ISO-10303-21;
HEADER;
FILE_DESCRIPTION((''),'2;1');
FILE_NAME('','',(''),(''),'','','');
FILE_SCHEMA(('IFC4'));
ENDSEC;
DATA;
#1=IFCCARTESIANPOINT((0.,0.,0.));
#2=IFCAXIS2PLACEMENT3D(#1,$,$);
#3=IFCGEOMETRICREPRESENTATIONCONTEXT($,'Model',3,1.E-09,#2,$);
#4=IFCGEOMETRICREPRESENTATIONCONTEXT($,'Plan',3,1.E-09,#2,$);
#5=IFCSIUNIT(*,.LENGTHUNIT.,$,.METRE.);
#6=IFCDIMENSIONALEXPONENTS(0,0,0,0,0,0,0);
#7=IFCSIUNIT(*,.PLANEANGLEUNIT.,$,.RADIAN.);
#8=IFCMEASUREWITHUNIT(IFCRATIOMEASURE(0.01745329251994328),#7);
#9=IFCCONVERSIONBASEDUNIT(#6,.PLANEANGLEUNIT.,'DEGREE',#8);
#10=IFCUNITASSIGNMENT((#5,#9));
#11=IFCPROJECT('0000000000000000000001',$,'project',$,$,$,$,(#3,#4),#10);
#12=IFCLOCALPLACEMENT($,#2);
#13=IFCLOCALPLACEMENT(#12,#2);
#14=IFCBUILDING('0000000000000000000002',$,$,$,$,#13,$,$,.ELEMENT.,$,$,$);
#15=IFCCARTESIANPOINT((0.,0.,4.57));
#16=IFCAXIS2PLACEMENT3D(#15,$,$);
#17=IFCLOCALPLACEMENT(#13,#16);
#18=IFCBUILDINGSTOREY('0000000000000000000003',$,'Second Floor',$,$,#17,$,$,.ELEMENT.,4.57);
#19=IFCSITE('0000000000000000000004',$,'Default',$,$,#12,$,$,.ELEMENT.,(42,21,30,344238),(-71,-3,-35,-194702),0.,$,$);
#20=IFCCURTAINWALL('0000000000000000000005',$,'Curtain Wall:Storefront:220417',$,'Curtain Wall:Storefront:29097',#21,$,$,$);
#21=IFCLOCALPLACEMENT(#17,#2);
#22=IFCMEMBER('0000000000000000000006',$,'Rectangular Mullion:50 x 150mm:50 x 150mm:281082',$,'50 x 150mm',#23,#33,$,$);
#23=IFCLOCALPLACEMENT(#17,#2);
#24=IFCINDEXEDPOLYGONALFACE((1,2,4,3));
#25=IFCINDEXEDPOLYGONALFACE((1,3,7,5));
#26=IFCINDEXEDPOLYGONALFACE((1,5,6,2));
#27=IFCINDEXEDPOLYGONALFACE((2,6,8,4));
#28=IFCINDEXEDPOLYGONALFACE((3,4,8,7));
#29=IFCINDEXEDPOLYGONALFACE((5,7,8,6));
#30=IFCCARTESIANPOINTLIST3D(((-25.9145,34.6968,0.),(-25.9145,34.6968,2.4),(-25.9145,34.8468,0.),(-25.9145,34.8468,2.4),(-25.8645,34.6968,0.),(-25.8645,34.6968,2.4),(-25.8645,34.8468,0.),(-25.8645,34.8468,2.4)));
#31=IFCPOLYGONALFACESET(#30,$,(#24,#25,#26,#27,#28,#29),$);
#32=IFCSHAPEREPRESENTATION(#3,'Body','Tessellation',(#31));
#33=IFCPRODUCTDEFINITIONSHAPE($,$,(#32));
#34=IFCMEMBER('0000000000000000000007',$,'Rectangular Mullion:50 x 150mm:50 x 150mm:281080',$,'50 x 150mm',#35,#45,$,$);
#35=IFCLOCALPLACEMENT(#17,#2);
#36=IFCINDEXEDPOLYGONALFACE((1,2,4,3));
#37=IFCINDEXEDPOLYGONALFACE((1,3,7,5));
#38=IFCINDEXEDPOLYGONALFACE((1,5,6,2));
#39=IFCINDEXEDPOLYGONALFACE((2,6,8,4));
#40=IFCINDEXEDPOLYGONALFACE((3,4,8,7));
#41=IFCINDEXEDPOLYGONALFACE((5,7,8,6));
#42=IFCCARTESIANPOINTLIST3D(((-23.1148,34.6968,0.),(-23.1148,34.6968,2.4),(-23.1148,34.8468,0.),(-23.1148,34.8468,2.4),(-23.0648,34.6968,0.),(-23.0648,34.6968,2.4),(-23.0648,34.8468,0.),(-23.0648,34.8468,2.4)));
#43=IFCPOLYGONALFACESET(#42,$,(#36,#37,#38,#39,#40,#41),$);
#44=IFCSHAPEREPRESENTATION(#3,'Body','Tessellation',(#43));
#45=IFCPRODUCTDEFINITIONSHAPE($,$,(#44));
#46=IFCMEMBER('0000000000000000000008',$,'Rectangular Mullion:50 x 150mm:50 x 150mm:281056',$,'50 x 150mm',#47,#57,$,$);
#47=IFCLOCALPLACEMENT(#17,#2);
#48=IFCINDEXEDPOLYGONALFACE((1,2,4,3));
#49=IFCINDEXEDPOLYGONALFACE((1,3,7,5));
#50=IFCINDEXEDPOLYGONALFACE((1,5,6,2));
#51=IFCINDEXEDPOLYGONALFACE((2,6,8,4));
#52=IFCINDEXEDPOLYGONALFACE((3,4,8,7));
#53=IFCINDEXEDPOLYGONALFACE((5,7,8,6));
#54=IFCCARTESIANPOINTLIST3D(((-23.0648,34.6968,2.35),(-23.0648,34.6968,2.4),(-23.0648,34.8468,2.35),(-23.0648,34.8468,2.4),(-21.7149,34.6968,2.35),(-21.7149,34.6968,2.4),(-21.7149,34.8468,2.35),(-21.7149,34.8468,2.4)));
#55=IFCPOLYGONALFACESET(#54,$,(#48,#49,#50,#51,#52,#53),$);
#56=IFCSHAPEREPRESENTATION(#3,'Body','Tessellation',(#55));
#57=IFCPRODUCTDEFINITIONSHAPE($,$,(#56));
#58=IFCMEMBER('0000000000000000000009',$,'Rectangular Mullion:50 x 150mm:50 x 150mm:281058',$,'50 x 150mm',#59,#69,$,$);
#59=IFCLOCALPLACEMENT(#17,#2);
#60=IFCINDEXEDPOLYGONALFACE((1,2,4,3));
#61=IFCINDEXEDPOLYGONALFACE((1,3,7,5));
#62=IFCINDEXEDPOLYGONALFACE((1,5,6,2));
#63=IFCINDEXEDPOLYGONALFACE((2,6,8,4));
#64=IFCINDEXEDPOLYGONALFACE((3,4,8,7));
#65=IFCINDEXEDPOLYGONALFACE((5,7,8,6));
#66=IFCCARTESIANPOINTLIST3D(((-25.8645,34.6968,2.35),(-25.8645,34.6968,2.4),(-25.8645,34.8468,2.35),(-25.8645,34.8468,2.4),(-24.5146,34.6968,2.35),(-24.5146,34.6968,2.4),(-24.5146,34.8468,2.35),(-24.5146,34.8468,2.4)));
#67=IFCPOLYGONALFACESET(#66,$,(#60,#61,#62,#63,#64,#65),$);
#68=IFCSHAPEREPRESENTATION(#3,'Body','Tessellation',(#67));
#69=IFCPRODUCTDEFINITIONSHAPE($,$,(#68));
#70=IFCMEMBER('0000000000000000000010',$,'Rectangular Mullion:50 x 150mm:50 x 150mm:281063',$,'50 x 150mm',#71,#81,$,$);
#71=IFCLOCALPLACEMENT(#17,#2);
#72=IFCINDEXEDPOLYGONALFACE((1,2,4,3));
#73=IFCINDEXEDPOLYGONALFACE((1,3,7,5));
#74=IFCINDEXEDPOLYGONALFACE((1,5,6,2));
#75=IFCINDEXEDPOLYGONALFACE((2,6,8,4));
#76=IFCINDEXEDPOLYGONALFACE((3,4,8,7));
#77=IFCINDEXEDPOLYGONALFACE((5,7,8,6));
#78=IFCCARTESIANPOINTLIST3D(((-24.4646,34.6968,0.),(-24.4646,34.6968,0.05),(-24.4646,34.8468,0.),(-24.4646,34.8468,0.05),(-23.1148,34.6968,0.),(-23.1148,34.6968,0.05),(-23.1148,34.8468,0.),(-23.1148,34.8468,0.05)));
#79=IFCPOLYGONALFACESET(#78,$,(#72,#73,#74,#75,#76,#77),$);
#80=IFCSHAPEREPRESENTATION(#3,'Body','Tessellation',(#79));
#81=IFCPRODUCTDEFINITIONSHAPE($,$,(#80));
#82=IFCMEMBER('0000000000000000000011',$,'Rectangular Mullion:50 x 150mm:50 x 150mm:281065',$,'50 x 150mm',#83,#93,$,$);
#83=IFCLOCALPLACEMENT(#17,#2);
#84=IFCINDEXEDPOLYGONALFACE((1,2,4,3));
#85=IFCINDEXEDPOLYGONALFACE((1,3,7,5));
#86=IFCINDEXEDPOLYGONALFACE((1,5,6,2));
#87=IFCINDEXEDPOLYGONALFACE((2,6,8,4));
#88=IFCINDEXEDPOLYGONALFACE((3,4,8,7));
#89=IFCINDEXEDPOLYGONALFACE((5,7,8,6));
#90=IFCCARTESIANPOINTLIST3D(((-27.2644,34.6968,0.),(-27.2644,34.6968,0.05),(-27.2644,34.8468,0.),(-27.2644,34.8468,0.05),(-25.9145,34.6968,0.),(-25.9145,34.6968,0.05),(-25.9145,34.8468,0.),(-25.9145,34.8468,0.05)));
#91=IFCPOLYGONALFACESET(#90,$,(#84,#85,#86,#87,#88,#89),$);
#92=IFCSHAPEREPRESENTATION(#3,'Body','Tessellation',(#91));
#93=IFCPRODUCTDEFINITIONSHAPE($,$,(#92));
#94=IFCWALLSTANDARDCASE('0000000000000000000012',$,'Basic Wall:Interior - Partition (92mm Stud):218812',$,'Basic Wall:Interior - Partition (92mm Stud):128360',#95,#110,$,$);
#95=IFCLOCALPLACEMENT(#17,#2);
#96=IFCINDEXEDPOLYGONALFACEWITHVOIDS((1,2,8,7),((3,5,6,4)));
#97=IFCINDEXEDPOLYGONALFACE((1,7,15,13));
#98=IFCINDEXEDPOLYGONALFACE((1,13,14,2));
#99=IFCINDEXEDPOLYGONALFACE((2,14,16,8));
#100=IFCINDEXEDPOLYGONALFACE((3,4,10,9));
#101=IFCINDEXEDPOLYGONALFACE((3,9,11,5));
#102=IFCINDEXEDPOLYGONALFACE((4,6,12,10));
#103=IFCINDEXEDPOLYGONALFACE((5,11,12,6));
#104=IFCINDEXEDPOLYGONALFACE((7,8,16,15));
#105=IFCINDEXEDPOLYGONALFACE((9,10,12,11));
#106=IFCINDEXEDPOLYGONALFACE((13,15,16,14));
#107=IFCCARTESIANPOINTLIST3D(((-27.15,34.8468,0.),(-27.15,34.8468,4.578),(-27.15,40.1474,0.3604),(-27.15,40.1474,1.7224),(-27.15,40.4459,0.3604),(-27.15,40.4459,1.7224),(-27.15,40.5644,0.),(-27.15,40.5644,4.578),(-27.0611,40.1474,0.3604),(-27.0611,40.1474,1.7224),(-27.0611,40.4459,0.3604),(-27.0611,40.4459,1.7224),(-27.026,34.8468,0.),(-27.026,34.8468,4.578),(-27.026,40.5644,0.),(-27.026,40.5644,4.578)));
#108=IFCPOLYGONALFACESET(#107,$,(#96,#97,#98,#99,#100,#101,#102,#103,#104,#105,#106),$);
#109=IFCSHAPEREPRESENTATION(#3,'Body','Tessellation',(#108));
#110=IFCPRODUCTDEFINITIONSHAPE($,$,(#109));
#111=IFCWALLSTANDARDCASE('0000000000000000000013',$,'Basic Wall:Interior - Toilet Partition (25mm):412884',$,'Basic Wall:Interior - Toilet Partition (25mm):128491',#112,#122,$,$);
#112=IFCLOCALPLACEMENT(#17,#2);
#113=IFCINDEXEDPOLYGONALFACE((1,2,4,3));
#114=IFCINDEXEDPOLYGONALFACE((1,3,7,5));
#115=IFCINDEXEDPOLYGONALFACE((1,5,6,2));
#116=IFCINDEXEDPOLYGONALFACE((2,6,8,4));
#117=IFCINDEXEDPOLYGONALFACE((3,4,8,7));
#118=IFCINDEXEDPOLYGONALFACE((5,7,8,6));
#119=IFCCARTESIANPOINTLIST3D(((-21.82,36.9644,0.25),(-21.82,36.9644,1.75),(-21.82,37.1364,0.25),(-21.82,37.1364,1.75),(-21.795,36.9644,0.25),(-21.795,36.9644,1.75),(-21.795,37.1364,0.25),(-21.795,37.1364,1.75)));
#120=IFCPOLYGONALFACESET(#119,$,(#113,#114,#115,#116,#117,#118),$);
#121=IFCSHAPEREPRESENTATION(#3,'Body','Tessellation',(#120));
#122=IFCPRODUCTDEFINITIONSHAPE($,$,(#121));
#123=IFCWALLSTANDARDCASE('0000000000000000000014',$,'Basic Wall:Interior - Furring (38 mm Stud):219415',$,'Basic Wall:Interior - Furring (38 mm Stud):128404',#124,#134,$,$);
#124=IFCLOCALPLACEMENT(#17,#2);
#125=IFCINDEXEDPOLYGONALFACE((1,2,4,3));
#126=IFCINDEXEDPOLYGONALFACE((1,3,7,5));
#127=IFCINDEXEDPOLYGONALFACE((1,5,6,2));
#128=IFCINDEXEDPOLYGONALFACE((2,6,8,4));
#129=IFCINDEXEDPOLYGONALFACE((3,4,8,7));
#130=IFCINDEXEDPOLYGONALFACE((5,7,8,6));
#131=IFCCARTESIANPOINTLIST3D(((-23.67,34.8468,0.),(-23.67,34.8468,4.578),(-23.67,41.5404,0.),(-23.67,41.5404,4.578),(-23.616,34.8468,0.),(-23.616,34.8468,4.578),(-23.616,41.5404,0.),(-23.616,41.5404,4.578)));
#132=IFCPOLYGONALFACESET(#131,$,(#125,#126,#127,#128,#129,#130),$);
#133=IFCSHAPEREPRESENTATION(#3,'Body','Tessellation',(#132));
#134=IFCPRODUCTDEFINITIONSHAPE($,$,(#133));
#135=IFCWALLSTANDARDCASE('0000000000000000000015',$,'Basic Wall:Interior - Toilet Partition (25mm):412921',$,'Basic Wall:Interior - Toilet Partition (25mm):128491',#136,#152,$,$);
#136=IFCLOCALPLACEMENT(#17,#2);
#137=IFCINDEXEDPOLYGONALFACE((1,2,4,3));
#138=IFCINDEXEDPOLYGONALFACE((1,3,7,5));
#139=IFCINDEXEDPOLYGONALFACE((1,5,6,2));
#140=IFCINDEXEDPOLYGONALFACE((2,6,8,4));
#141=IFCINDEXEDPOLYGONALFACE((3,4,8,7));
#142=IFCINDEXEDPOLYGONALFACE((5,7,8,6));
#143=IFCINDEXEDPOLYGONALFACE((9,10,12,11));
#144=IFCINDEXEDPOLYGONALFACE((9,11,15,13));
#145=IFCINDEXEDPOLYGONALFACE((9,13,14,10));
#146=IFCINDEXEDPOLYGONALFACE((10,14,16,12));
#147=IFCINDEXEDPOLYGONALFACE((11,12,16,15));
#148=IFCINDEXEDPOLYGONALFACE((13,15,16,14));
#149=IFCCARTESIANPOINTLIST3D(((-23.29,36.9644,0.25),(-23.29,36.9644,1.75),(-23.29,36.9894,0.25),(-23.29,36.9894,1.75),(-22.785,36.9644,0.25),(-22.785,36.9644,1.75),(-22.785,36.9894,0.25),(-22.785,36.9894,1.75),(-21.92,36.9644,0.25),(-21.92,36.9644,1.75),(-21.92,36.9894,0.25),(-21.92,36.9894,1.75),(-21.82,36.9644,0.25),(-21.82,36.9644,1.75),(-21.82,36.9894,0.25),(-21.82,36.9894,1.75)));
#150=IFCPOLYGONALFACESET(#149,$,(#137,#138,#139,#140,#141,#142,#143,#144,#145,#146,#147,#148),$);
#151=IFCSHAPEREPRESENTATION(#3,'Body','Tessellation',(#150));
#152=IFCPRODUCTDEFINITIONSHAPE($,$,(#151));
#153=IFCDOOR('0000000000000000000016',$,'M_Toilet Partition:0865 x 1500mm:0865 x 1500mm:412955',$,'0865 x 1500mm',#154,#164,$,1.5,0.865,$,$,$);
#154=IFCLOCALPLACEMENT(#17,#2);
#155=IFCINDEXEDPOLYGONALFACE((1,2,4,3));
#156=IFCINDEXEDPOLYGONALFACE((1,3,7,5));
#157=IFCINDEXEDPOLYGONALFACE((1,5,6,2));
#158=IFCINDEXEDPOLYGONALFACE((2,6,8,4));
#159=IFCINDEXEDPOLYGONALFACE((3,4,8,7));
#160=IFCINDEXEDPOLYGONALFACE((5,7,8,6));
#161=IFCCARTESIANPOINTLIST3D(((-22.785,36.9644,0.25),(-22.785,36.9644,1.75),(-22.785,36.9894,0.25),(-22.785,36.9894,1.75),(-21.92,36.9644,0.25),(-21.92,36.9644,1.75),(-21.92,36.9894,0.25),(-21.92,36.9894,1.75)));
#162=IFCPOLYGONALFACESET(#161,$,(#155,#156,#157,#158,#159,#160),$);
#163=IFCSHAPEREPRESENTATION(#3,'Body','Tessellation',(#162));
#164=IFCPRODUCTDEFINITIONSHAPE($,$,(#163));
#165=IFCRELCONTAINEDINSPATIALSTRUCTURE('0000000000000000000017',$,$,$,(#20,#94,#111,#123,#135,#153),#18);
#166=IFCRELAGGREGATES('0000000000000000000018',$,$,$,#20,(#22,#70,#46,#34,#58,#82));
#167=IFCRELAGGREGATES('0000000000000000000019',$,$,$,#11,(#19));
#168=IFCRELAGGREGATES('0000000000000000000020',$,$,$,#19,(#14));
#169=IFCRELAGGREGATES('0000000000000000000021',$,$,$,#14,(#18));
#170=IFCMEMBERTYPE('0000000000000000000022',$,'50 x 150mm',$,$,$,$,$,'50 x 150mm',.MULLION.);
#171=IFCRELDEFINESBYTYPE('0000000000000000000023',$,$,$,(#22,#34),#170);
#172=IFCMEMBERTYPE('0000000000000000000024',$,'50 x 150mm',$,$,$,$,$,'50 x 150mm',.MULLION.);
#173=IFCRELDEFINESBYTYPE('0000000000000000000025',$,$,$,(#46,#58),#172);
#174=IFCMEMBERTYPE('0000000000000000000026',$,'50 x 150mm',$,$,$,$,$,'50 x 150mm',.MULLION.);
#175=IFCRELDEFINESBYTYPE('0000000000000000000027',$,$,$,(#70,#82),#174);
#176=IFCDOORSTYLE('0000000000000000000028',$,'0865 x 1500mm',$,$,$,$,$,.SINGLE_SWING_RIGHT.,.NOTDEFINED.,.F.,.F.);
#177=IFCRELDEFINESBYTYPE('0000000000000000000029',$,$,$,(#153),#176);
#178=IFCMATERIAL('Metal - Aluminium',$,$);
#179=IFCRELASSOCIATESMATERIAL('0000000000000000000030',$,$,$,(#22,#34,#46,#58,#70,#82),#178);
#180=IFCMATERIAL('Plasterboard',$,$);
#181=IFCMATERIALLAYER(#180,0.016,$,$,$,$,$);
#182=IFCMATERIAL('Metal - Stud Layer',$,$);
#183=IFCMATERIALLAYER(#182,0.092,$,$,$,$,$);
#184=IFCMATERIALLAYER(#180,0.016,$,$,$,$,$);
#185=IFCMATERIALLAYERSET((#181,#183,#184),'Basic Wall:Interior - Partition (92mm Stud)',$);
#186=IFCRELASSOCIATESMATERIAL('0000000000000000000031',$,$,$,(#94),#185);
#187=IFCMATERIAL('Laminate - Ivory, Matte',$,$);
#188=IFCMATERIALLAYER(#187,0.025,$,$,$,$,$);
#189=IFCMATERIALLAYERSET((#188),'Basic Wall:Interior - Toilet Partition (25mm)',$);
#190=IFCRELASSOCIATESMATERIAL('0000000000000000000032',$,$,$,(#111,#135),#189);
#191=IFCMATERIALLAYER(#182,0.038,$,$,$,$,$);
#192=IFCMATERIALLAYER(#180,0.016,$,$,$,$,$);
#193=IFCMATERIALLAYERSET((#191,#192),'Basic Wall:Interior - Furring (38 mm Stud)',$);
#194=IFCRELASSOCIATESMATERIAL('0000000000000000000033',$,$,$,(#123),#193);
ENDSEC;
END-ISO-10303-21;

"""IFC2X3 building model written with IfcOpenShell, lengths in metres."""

from ifc_helpers import new_model, entity, si_unit, converted_unit, frame, frame_2d, origin, origin_2d_with_axis, place, context, project, spatial, rectangle, extrude, source, transform, mapped, material, layer, layer_set, layer_usage, type_object, type_shapes, element, fill, aggregate, save


model = new_model("IFC2X3")

# Units and contexts
model_context = context("Model", 3, precision=1e-09, world=origin())
plan_context = context("Plan", 3, precision=1e-09, world=origin())
ifc_project = project(units=[si_unit("LENGTHUNIT", "METRE"), converted_unit("PLANEANGLEUNIT", "DEGREE", entity("IfcRatioMeasure", 0.01745329251994328), si_unit("PLANEANGLEUNIT", "RADIAN"), dimensions=[0, 0, 0, 0, 0, 0, 0])], contexts=[model_context, plan_context])

# Site, building, storey
site_placement = place(None, origin())
site = spatial("IfcSite", under=ifc_project, at=site_placement, Name="Default", CompositionType="ELEMENT", RefLatitude=(42, 21, 30, 344238), RefLongitude=(-71, -3, -35, -194702), RefElevation=0.0)
building_placement = place(site_placement, origin())
building = spatial("IfcBuilding", under=site, at=building_placement, CompositionType="ELEMENT")
storey_placement = place(building_placement, frame((0.0, 0.0, 4.57)))
storey = spatial("IfcBuildingStorey", under=building, at=storey_placement, Name="Second Floor", CompositionType="ELEMENT", Elevation=4.57)

# Curtain wall, members
curtain_wall_placement = place(storey_placement, origin())
curtain_wall = element("IfcCurtainWall", 1, at=curtain_wall_placement, inside=storey, Name="Curtain Wall:Storefront:220417", ObjectType="Curtain Wall:Storefront:29097")
ifc_material_1 = material(Name="Metal - Aluminium")
member_type_1 = type_object("IfcMemberType", Name="50 x 150mm", ElementType="50 x 150mm", PredefinedType="MULLION")
shared_shape_1 = source(origin(), model_context, "Body", "SweptSolid", [
    extrude(rectangle(XDim=0.05, YDim=0.15, at=origin_2d_with_axis()), frame((0.0, 0.0, -2.4), z_axis=(0.0, 0.0, 1.0), x_axis=(-1.0, 0.0, 0.0)), (0.0, 0.0, 1.0), 2.4),
])
type_shapes(member_type_1, [shared_shape_1])
member_1_placement = place(storey_placement, frame((-25.8895, 34.7718, 0.0), z_axis=(0.0, 0.0, -1.0), x_axis=(-1.0, 0.0, 0.0)))
member_1 = element("IfcMember", 2, at=member_1_placement, type_object=member_type_1, material=ifc_material_1, Name="Rectangular Mullion:50 x 150mm:50 x 150mm:281082", ObjectType="50 x 150mm", context=model_context, shape_type="MappedRepresentation", body=[
    mapped(shared_shape_1, transform((0.0, 0.0, 0.0), scale=1.0)),
])
member_2_placement = place(storey_placement, frame((-23.0898, 34.7718, 0.0), z_axis=(0.0, 0.0, -1.0), x_axis=(-1.0, 0.0, 0.0)))
member_2 = element("IfcMember", 3, at=member_2_placement, type_object=member_type_1, material=ifc_material_1, Name="Rectangular Mullion:50 x 150mm:50 x 150mm:281080", ObjectType="50 x 150mm", context=model_context, shape_type="MappedRepresentation", body=[
    mapped(shared_shape_1, transform((0.0, 0.0, 0.0), scale=1.0)),
])
member_type_2 = type_object("IfcMemberType", Name="50 x 150mm", ElementType="50 x 150mm", PredefinedType="MULLION")
shared_shape_2 = source(origin(), model_context, "Body", "SweptSolid", [
    extrude(rectangle(XDim=0.05, YDim=0.15, at=origin_2d_with_axis()), frame((-0.025, 0.0, -1.3499), z_axis=(0.0, 0.0, 1.0), x_axis=(-1.0, 0.0, 0.0)), (0.0, 0.0, 1.0), 1.3499),
])
type_shapes(member_type_2, [shared_shape_2])
member_3_placement = place(storey_placement, frame((-23.0648, 34.7718, 2.4), z_axis=(-1.0, 0.0, 0.0), x_axis=(0.0, 0.0, 1.0)))
member_3 = element("IfcMember", 4, at=member_3_placement, type_object=member_type_2, material=ifc_material_1, Name="Rectangular Mullion:50 x 150mm:50 x 150mm:281056", ObjectType="50 x 150mm", context=model_context, shape_type="MappedRepresentation", body=[
    mapped(shared_shape_2, transform((0.0, 0.0, 0.0), scale=1.0)),
])
member_4_placement = place(storey_placement, frame((-25.8645, 34.7718, 2.4), z_axis=(-1.0, 0.0, 0.0), x_axis=(0.0, 0.0, 1.0)))
member_4 = element("IfcMember", 5, at=member_4_placement, type_object=member_type_2, material=ifc_material_1, Name="Rectangular Mullion:50 x 150mm:50 x 150mm:281058", ObjectType="50 x 150mm", context=model_context, shape_type="MappedRepresentation", body=[
    mapped(shared_shape_2, transform((0.0, 0.0, 0.0), scale=1.0)),
])
member_type_3 = type_object("IfcMemberType", Name="50 x 150mm", ElementType="50 x 150mm", PredefinedType="MULLION")
shared_shape_3 = source(origin(), model_context, "Body", "SweptSolid", [
    extrude(rectangle(XDim=0.05, YDim=0.15, at=origin_2d_with_axis()), frame((-0.025, 0.0, -1.3499), z_axis=(0.0, 0.0, 1.0), x_axis=(-1.0, 0.0, 0.0)), (0.0, 0.0, 1.0), 1.3499),
])
type_shapes(member_type_3, [shared_shape_3])
member_5_placement = place(storey_placement, frame((-23.1148, 34.7718, 0.0), z_axis=(1.0, 0.0, 0.0), x_axis=(0.0, 0.0, -1.0)))
member_5 = element("IfcMember", 6, at=member_5_placement, type_object=member_type_3, material=ifc_material_1, Name="Rectangular Mullion:50 x 150mm:50 x 150mm:281063", ObjectType="50 x 150mm", context=model_context, shape_type="MappedRepresentation", body=[
    mapped(shared_shape_3, transform((0.0, 0.0, 0.0), scale=1.0)),
])
member_6_placement = place(storey_placement, frame((-25.9145, 34.7718, 0.0), z_axis=(1.0, 0.0, 0.0), x_axis=(0.0, 0.0, -1.0)))
member_6 = element("IfcMember", 7, at=member_6_placement, type_object=member_type_3, material=ifc_material_1, Name="Rectangular Mullion:50 x 150mm:50 x 150mm:281065", ObjectType="50 x 150mm", context=model_context, shape_type="MappedRepresentation", body=[
    mapped(shared_shape_3, transform((0.0, 0.0, 0.0), scale=1.0)),
])
aggregate(curtain_wall, [member_1, member_5, member_3, member_2, member_4, member_6])

# Wall, opening
ifc_material_2 = material(Name="Plasterboard")
ifc_layer_1 = layer(ifc_material_2, 0.016)
ifc_material_3 = material(Name="Metal - Stud Layer")
ifc_layer_2 = layer(ifc_material_3, 0.092)
ifc_layer_3 = layer(ifc_material_2, 0.016)
ifc_layer_set_1 = layer_set([ifc_layer_1, ifc_layer_2, ifc_layer_3], Name="Basic Wall:Interior - Partition (92mm Stud)")
ifc_layer_usage_1 = layer_usage(ifc_layer_set_1, "AXIS2", "NEGATIVE", 0.062)
wall_1_placement = place(storey_placement, frame((-27.088, 34.8468, 0.0), z_axis=(0.0, 0.0, 1.0), x_axis=(0.0, 1.0, 0.0)))
wall_1 = element("IfcWallStandardCase", 8, at=wall_1_placement, inside=storey, material=ifc_layer_usage_1, Name="Basic Wall:Interior - Partition (92mm Stud):218812", ObjectType="Basic Wall:Interior - Partition (92mm Stud):128360", context=model_context, shape_type="SweptSolid", body=[
    extrude(rectangle(XDim=5.7176, YDim=0.124, at=frame_2d((2.8588, 0.0), x_axis=(-1.0, 0.0))), origin(), (0.0, 0.0, 1.0), 4.578),
])
opening_1_placement = place(wall_1_placement, origin())
element("IfcOpeningElement", 9, at=opening_1_placement, cuts=wall_1, ObjectType="Opening", context=model_context, shape_type="SweptSolid", body=[
    extrude(rectangle(XDim=1.3621, YDim=0.2984, at=frame_2d((0.0, 0.0), x_axis=(0.0, 1.0))), frame((5.4498, -0.0269, 1.0414), z_axis=(0.0, 1.0, 0.0), x_axis=(1.0, 0.0, 0.0)), (0.0, 0.0, 1.0), 0.1524),
])

# Walls
ifc_material_4 = material(Name="Laminate - Ivory, Matte")
ifc_layer_4 = layer(ifc_material_4, 0.025)
ifc_layer_set_2 = layer_set([ifc_layer_4], Name="Basic Wall:Interior - Toilet Partition (25mm)")
ifc_layer_usage_2 = layer_usage(ifc_layer_set_2, "AXIS2", "NEGATIVE", 0.0125)
wall_2_placement = place(storey_placement, frame((-21.8075, 37.1364, 0.25), z_axis=(0.0, 0.0, 1.0), x_axis=(0.0, -1.0, 0.0)))
element("IfcWallStandardCase", 10, at=wall_2_placement, inside=storey, material=ifc_layer_usage_2, Name="Basic Wall:Interior - Toilet Partition (25mm):412884", ObjectType="Basic Wall:Interior - Toilet Partition (25mm):128491", context=model_context, shape_type="SweptSolid", body=[
    extrude(rectangle(XDim=0.1721, YDim=0.025, at=frame_2d((0.086, 0.0), x_axis=(-1.0, 0.0))), origin(), (0.0, 0.0, 1.0), 1.5),
])
ifc_layer_5 = layer(ifc_material_3, 0.038)
ifc_layer_6 = layer(ifc_material_2, 0.016)
ifc_layer_set_3 = layer_set([ifc_layer_5, ifc_layer_6], Name="Basic Wall:Interior - Furring (38 mm Stud)")
ifc_layer_usage_3 = layer_usage(ifc_layer_set_3, "AXIS2", "POSITIVE", -0.027)
wall_3_placement = place(storey_placement, frame((-23.643, 34.8468, 0.0), z_axis=(0.0, 0.0, 1.0), x_axis=(0.0, 1.0, 0.0)))
element("IfcWallStandardCase", 11, at=wall_3_placement, inside=storey, material=ifc_layer_usage_3, Name="Basic Wall:Interior - Furring (38 mm Stud):219415", ObjectType="Basic Wall:Interior - Furring (38 mm Stud):128404", context=model_context, shape_type="SweptSolid", body=[
    extrude(rectangle(XDim=6.6936, YDim=0.054, at=frame_2d((3.3468, 0.0), x_axis=(-1.0, 0.0))), origin(), (0.0, 0.0, 1.0), 4.578),
])

# Wall, opening, door
wall_4_placement = place(storey_placement, frame((-21.82, 36.9769, 0.25), z_axis=(0.0, 0.0, 1.0), x_axis=(-1.0, 0.0, 0.0)))
wall_4 = element("IfcWallStandardCase", 12, at=wall_4_placement, inside=storey, material=ifc_layer_usage_2, Name="Basic Wall:Interior - Toilet Partition (25mm):412921", ObjectType="Basic Wall:Interior - Toilet Partition (25mm):128491", context=model_context, shape_type="SweptSolid", body=[
    extrude(rectangle(XDim=1.47, YDim=0.025, at=frame_2d((0.735, 0.0), x_axis=(-1.0, 0.0))), origin(), (0.0, 0.0, 1.0), 1.5),
])
opening_2_placement = place(wall_4_placement, frame((0.1, -0.0125, 0.0)))
opening_2 = element("IfcOpeningElement", 13, at=opening_2_placement, cuts=wall_4, ObjectType="Opening", context=model_context, shape_type="SweptSolid", body=[
    extrude(rectangle(XDim=0.865, YDim=1.5, at=frame_2d((0.75, 0.4325), x_axis=(0.0, 1.0))), frame((0.0, 0.0, 0.0), z_axis=(0.0, 1.0, 0.0), x_axis=(0.0, 0.0, 1.0)), (0.0, 0.0, 1.0), 0.025),
])
door_style = type_object("IfcDoorStyle", Name="0865 x 1500mm", ConstructionType="NOTDEFINED", OperationType="SINGLE_SWING_RIGHT", ParameterTakesPrecedence=False, Sizeable=False)
shared_shape_4 = source(origin(), model_context, "Body", "SweptSolid", [
    extrude(rectangle(XDim=0.025, YDim=0.865, at=origin_2d_with_axis()), frame((0.4325, 0.0125, 0.0), z_axis=(0.0, 0.0, 1.0), x_axis=(0.0, 1.0, 0.0)), (0.0, 0.0, 1.0), 1.5),
])
type_shapes(door_style, [shared_shape_4])
door_placement = place(opening_2_placement, origin())
door = element("IfcDoor", 14, at=door_placement, inside=storey, type_object=door_style, Name="M_Toilet Partition:0865 x 1500mm:0865 x 1500mm:412955", ObjectType="0865 x 1500mm", OverallHeight=1.5, OverallWidth=0.865, context=model_context, shape_type="MappedRepresentation", body=[
    mapped(shared_shape_4, transform((0.0, 0.0, 0.0), scale=1.0)),
])
fill(opening_2, door)

save(model, "model.ifc")
